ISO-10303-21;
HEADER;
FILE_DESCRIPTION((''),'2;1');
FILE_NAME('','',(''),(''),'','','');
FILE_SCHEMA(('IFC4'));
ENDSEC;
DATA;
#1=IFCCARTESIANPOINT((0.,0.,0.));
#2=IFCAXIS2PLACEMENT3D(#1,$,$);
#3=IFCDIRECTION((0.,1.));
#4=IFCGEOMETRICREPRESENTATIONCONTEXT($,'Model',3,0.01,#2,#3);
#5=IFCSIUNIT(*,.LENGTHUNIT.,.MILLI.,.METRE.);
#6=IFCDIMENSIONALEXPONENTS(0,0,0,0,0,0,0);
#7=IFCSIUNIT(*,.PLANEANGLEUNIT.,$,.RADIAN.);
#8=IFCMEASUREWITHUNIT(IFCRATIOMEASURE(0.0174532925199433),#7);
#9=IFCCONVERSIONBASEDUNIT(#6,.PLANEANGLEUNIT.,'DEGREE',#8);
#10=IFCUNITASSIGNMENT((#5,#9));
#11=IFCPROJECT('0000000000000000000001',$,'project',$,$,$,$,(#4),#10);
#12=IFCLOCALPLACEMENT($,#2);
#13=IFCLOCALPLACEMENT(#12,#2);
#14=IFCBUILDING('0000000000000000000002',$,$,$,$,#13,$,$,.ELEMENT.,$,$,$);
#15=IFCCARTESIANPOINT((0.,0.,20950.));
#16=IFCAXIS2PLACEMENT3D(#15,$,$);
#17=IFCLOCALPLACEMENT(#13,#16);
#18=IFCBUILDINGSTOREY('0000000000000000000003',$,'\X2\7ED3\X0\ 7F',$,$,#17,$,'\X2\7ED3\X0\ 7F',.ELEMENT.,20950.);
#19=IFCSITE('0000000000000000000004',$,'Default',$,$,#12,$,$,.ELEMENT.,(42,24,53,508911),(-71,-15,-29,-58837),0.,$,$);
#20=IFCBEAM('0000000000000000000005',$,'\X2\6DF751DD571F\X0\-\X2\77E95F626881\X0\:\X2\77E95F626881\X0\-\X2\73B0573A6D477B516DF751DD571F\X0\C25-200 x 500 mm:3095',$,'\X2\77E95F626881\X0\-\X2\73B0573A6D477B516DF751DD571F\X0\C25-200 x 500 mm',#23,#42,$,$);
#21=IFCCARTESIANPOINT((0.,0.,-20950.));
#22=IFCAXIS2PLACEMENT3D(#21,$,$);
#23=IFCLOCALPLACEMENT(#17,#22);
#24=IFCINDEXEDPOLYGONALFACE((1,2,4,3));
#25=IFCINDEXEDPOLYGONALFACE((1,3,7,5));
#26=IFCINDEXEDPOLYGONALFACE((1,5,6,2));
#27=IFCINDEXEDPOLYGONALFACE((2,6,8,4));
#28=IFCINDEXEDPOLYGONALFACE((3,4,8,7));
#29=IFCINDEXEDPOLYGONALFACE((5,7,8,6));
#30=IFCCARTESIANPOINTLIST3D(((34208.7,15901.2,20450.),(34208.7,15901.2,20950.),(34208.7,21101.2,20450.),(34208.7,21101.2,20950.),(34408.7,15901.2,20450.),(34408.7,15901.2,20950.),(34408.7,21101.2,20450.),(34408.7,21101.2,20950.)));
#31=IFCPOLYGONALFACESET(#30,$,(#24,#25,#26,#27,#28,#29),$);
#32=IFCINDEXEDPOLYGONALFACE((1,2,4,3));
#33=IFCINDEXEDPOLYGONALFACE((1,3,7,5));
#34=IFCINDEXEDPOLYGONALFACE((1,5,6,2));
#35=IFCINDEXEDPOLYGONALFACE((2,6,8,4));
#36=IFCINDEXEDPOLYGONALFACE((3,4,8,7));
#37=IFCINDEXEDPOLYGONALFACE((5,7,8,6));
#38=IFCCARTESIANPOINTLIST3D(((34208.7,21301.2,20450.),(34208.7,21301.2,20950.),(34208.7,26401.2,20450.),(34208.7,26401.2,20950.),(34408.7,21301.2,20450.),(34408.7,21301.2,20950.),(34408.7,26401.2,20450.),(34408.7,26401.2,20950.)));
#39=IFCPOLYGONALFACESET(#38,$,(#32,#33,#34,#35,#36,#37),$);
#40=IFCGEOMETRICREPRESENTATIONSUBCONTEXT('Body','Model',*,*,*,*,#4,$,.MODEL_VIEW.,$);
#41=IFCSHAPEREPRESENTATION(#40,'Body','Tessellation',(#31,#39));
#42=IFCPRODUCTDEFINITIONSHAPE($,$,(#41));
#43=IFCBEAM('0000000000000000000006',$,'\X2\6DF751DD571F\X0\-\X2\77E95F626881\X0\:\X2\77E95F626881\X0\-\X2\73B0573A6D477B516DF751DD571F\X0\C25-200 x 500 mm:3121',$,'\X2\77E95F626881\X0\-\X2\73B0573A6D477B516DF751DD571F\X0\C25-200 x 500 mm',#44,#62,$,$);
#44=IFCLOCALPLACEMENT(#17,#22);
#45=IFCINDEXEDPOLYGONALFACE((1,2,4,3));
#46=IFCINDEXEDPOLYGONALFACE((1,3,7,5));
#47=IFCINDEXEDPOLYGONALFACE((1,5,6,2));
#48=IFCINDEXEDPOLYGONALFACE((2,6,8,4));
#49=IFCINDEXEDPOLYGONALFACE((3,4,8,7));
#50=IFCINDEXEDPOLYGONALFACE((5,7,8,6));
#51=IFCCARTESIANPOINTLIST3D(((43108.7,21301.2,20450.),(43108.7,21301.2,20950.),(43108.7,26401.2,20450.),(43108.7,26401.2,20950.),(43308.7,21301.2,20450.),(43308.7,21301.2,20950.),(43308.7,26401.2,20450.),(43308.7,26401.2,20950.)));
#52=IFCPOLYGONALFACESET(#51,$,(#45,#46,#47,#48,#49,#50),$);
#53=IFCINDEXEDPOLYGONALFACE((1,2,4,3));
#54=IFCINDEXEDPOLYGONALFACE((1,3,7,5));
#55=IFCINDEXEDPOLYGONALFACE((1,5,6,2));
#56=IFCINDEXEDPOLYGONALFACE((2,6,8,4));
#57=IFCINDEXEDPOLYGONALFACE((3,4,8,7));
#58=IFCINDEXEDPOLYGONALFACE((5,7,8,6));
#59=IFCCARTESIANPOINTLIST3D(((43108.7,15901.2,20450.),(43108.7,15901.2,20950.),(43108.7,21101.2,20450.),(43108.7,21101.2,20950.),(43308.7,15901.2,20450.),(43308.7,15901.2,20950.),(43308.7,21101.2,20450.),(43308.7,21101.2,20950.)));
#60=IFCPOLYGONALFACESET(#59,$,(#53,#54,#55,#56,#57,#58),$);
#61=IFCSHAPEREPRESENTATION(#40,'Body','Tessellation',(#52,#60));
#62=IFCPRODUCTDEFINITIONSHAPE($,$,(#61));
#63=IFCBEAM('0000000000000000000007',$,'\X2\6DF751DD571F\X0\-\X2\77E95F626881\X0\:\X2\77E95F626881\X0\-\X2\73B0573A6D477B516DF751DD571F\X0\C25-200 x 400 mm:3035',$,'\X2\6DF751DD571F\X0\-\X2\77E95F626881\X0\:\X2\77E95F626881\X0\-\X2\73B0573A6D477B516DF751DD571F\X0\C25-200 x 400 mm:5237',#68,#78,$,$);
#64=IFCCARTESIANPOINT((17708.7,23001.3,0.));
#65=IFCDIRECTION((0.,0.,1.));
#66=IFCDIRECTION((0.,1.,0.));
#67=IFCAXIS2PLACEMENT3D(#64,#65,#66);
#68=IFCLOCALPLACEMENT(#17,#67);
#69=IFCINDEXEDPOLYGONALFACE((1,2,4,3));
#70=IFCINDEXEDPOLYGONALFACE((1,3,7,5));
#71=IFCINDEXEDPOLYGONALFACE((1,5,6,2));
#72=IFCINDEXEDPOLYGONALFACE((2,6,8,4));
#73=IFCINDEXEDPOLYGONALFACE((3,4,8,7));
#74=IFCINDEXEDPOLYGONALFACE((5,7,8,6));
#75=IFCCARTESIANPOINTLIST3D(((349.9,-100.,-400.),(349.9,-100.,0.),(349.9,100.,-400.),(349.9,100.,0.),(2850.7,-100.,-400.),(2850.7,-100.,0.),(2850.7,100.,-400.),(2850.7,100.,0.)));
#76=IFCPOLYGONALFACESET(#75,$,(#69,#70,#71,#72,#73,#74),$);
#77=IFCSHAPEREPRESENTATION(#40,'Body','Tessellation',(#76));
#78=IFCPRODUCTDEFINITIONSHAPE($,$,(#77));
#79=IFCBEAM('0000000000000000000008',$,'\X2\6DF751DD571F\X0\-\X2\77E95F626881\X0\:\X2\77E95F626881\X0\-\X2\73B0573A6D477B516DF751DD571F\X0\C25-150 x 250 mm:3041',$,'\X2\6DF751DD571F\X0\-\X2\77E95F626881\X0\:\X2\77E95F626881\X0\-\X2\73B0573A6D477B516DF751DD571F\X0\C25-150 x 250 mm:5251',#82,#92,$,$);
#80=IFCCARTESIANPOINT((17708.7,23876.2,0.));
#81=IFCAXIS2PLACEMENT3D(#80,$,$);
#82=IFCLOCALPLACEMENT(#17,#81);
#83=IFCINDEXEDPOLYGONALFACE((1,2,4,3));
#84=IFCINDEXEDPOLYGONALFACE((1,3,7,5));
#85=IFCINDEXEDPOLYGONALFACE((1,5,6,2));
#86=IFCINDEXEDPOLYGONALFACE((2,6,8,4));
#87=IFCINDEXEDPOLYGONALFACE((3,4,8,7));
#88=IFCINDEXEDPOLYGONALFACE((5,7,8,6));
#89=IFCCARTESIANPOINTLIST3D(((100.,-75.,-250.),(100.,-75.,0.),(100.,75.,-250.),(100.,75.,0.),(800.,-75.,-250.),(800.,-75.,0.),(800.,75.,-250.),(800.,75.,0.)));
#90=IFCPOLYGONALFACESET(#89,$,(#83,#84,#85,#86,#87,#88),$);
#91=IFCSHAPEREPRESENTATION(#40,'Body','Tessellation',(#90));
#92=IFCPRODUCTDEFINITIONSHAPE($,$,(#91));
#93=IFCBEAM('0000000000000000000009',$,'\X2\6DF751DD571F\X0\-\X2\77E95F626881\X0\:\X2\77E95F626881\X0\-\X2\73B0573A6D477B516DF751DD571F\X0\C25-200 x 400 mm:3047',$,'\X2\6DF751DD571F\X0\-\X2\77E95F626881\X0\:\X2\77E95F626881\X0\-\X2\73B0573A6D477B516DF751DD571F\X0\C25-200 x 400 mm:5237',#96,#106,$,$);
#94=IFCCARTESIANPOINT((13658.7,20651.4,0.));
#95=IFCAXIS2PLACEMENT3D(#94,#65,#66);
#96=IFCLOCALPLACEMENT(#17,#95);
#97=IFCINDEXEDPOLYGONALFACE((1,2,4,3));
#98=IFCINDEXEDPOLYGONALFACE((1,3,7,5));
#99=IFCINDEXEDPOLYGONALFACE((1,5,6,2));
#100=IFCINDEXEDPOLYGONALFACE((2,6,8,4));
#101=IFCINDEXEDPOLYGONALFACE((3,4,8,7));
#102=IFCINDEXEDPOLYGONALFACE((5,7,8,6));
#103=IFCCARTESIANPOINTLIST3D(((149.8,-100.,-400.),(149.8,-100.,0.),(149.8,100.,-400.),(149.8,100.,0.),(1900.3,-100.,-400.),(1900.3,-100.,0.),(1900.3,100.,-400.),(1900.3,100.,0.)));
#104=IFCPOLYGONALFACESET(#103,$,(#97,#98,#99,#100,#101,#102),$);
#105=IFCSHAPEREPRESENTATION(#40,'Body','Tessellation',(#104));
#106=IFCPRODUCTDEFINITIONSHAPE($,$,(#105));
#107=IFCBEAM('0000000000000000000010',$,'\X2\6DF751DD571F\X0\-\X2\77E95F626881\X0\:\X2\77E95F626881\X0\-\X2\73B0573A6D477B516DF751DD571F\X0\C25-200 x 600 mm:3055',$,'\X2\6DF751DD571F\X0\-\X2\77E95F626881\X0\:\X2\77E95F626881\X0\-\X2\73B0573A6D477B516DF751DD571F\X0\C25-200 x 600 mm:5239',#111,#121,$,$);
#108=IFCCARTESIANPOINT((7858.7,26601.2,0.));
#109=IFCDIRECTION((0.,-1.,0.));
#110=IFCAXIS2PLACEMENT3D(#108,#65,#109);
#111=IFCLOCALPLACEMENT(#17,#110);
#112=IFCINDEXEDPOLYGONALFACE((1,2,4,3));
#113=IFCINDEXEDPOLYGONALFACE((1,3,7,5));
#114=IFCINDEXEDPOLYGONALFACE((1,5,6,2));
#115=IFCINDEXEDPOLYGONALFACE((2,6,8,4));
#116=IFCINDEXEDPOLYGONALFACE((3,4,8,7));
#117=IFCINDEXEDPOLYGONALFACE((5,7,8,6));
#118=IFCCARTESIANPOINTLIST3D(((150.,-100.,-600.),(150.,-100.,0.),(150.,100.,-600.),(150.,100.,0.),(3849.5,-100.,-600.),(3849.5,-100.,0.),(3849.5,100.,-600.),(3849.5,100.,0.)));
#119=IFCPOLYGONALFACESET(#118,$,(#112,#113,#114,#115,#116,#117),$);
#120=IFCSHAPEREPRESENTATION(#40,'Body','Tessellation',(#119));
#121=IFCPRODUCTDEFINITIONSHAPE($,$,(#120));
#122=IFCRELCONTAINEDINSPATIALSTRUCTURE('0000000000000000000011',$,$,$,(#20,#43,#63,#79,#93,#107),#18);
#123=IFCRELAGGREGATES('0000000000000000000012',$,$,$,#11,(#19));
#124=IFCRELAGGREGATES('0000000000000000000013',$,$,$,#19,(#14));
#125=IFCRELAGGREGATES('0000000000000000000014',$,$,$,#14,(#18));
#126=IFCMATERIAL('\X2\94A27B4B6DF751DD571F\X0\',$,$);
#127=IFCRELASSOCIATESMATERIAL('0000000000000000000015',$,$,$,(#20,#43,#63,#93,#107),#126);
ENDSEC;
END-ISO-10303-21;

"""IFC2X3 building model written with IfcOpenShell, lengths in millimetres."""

from ifc_helpers import new_model, entity, si_unit, converted_unit, direction, frame, frame_2d, origin, place, context, subcontext, project, spatial, rectangle, extrude, source, transform, mapped, material, element, save


model = new_model("IFC2X3")

# Units and contexts
model_context = context("Model", 3, precision=0.01, world=origin(), true_north=direction((0.0, 1.0)))
body_context = subcontext(model_context, "Body", "Model", "MODEL_VIEW")
ifc_project = project(units=[si_unit("LENGTHUNIT", "METRE", prefix="MILLI"), converted_unit("PLANEANGLEUNIT", "DEGREE", entity("IfcRatioMeasure", 0.0174532925199433), si_unit("PLANEANGLEUNIT", "RADIAN"), dimensions=[0, 0, 0, 0, 0, 0, 0])], contexts=[model_context])

# Site, building, storey
site_placement = place(None, origin())
site = spatial("IfcSite", under=ifc_project, at=site_placement, Name="Default", CompositionType="ELEMENT", RefLatitude=(42, 24, 53, 508911), RefLongitude=(-71, -15, -29, -58837), RefElevation=0.0)
building_placement = place(site_placement, origin())
building = spatial("IfcBuilding", under=site, at=building_placement, CompositionType="ELEMENT")
storey_placement = place(building_placement, frame((0.0, 0.0, 20950.0)))
storey = spatial("IfcBuildingStorey", under=building, at=storey_placement, Name="结 7F", LongName="结 7F", CompositionType="ELEMENT", Elevation=20950.0)

# Beams
ifc_material = material(Name="钢筋混凝土")
shared_shape_1 = source(origin(), body_context, "Body", "SweptSolid", [
    extrude(rectangle(XDim=5200.1, YDim=200.0, at=frame_2d((-849.8, 0.0), x_axis=(1.0, 0.0))), frame((34308.7, 17651.5, 20450.0), z_axis=(0.0, 0.0, 1.0), x_axis=(0.0, -1.0, 0.0)), (0.0, 0.0, 1.0), 500.0),
    extrude(rectangle(XDim=5100.0, YDim=200.0, at=frame_2d((0.0, 0.0), x_axis=(1.0, 0.0))), frame((34308.7, 23851.2, 20450.0), z_axis=(0.0, 0.0, 1.0), x_axis=(0.0, 1.0, 0.0)), (0.0, 0.0, 1.0), 500.0),
])
beam_1_placement = place(storey_placement, frame((0.0, 0.0, -20950.0)))
element("IfcBeam", 1, at=beam_1_placement, inside=storey, material=ifc_material, Name="混凝土-矩形梁:矩形梁-现场浇筑混凝土C25-200 x 500 mm:3095", ObjectType="矩形梁-现场浇筑混凝土C25-200 x 500 mm", context=body_context, shape_type="MappedRepresentation", body=[
    mapped(shared_shape_1, transform((0.0, 0.0, 0.0), scale=1.0)),
])
shared_shape_2 = source(origin(), body_context, "Body", "SweptSolid", [
    extrude(rectangle(XDim=5100.0, YDim=200.0, at=frame_2d((0.0, 0.0), x_axis=(1.0, 0.0))), frame((43208.7, 23851.2, 20450.0), z_axis=(0.0, 0.0, 1.0), x_axis=(0.0, 1.0, 0.0)), (0.0, 0.0, 1.0), 500.0),
    extrude(rectangle(XDim=5200.1, YDim=200.0, at=frame_2d((-849.8, 0.0), x_axis=(1.0, 0.0))), frame((43208.7, 17651.5, 20450.0), z_axis=(0.0, 0.0, 1.0), x_axis=(0.0, -1.0, 0.0)), (0.0, 0.0, 1.0), 500.0),
])
beam_2_placement = place(storey_placement, frame((0.0, 0.0, -20950.0)))
element("IfcBeam", 2, at=beam_2_placement, inside=storey, material=ifc_material, Name="混凝土-矩形梁:矩形梁-现场浇筑混凝土C25-200 x 500 mm:3121", ObjectType="矩形梁-现场浇筑混凝土C25-200 x 500 mm", context=body_context, shape_type="MappedRepresentation", body=[
    mapped(shared_shape_2, transform((0.0, 0.0, 0.0), scale=1.0)),
])
beam_3_placement = place(storey_placement, frame((17708.7, 23001.3, 0.0), z_axis=(0.0, 0.0, 1.0), x_axis=(0.0, 1.0, 0.0)))
element("IfcBeam", 3, at=beam_3_placement, inside=storey, material=ifc_material, Name="混凝土-矩形梁:矩形梁-现场浇筑混凝土C25-200 x 400 mm:3035", ObjectType="混凝土-矩形梁:矩形梁-现场浇筑混凝土C25-200 x 400 mm:5237", context=body_context, shape_type="SweptSolid", body=[
    extrude(rectangle(XDim=400.0, YDim=200.0, at=frame_2d((0.0, 0.0), x_axis=(1.0, 0.0))), frame((349.9, 0.0, -200.0), z_axis=(1.0, 0.0, 0.0), x_axis=(0.0, 0.0, -1.0)), (0.0, 0.0, 1.0), 2500.8),
])
beam_4_placement = place(storey_placement, frame((17708.7, 23876.2, 0.0)))
element("IfcBeam", 4, at=beam_4_placement, inside=storey, Name="混凝土-矩形梁:矩形梁-现场浇筑混凝土C25-150 x 250 mm:3041", ObjectType="混凝土-矩形梁:矩形梁-现场浇筑混凝土C25-150 x 250 mm:5251", context=body_context, shape_type="SweptSolid", body=[
    extrude(rectangle(XDim=250.0, YDim=150.0, at=frame_2d((0.0, 0.0), x_axis=(1.0, 0.0))), frame((100.0, 0.0, -125.0), z_axis=(1.0, 0.0, 0.0), x_axis=(0.0, 0.0, -1.0)), (0.0, 0.0, 1.0), 700.0),
])
beam_5_placement = place(storey_placement, frame((13658.7, 20651.4, 0.0), z_axis=(0.0, 0.0, 1.0), x_axis=(0.0, 1.0, 0.0)))
element("IfcBeam", 5, at=beam_5_placement, inside=storey, material=ifc_material, Name="混凝土-矩形梁:矩形梁-现场浇筑混凝土C25-200 x 400 mm:3047", ObjectType="混凝土-矩形梁:矩形梁-现场浇筑混凝土C25-200 x 400 mm:5237", context=body_context, shape_type="SweptSolid", body=[
    extrude(rectangle(XDim=400.0, YDim=200.0, at=frame_2d((0.0, 0.0), x_axis=(1.0, 0.0))), frame((149.8, 0.0, -200.0), z_axis=(1.0, 0.0, 0.0), x_axis=(0.0, 0.0, -1.0)), (0.0, 0.0, 1.0), 1750.5),
])
beam_6_placement = place(storey_placement, frame((7858.7, 26601.2, 0.0), z_axis=(0.0, 0.0, 1.0), x_axis=(0.0, -1.0, 0.0)))
element("IfcBeam", 6, at=beam_6_placement, inside=storey, material=ifc_material, Name="混凝土-矩形梁:矩形梁-现场浇筑混凝土C25-200 x 600 mm:3055", ObjectType="混凝土-矩形梁:矩形梁-现场浇筑混凝土C25-200 x 600 mm:5239", context=body_context, shape_type="SweptSolid", body=[
    extrude(rectangle(XDim=600.0, YDim=200.0, at=frame_2d((0.0, 0.0), x_axis=(1.0, 0.0))), frame((150.0, 0.0, -300.0), z_axis=(1.0, 0.0, 0.0), x_axis=(0.0, 0.0, -1.0)), (0.0, 0.0, 1.0), 3699.5),
])

save(model, "model.ifc")
